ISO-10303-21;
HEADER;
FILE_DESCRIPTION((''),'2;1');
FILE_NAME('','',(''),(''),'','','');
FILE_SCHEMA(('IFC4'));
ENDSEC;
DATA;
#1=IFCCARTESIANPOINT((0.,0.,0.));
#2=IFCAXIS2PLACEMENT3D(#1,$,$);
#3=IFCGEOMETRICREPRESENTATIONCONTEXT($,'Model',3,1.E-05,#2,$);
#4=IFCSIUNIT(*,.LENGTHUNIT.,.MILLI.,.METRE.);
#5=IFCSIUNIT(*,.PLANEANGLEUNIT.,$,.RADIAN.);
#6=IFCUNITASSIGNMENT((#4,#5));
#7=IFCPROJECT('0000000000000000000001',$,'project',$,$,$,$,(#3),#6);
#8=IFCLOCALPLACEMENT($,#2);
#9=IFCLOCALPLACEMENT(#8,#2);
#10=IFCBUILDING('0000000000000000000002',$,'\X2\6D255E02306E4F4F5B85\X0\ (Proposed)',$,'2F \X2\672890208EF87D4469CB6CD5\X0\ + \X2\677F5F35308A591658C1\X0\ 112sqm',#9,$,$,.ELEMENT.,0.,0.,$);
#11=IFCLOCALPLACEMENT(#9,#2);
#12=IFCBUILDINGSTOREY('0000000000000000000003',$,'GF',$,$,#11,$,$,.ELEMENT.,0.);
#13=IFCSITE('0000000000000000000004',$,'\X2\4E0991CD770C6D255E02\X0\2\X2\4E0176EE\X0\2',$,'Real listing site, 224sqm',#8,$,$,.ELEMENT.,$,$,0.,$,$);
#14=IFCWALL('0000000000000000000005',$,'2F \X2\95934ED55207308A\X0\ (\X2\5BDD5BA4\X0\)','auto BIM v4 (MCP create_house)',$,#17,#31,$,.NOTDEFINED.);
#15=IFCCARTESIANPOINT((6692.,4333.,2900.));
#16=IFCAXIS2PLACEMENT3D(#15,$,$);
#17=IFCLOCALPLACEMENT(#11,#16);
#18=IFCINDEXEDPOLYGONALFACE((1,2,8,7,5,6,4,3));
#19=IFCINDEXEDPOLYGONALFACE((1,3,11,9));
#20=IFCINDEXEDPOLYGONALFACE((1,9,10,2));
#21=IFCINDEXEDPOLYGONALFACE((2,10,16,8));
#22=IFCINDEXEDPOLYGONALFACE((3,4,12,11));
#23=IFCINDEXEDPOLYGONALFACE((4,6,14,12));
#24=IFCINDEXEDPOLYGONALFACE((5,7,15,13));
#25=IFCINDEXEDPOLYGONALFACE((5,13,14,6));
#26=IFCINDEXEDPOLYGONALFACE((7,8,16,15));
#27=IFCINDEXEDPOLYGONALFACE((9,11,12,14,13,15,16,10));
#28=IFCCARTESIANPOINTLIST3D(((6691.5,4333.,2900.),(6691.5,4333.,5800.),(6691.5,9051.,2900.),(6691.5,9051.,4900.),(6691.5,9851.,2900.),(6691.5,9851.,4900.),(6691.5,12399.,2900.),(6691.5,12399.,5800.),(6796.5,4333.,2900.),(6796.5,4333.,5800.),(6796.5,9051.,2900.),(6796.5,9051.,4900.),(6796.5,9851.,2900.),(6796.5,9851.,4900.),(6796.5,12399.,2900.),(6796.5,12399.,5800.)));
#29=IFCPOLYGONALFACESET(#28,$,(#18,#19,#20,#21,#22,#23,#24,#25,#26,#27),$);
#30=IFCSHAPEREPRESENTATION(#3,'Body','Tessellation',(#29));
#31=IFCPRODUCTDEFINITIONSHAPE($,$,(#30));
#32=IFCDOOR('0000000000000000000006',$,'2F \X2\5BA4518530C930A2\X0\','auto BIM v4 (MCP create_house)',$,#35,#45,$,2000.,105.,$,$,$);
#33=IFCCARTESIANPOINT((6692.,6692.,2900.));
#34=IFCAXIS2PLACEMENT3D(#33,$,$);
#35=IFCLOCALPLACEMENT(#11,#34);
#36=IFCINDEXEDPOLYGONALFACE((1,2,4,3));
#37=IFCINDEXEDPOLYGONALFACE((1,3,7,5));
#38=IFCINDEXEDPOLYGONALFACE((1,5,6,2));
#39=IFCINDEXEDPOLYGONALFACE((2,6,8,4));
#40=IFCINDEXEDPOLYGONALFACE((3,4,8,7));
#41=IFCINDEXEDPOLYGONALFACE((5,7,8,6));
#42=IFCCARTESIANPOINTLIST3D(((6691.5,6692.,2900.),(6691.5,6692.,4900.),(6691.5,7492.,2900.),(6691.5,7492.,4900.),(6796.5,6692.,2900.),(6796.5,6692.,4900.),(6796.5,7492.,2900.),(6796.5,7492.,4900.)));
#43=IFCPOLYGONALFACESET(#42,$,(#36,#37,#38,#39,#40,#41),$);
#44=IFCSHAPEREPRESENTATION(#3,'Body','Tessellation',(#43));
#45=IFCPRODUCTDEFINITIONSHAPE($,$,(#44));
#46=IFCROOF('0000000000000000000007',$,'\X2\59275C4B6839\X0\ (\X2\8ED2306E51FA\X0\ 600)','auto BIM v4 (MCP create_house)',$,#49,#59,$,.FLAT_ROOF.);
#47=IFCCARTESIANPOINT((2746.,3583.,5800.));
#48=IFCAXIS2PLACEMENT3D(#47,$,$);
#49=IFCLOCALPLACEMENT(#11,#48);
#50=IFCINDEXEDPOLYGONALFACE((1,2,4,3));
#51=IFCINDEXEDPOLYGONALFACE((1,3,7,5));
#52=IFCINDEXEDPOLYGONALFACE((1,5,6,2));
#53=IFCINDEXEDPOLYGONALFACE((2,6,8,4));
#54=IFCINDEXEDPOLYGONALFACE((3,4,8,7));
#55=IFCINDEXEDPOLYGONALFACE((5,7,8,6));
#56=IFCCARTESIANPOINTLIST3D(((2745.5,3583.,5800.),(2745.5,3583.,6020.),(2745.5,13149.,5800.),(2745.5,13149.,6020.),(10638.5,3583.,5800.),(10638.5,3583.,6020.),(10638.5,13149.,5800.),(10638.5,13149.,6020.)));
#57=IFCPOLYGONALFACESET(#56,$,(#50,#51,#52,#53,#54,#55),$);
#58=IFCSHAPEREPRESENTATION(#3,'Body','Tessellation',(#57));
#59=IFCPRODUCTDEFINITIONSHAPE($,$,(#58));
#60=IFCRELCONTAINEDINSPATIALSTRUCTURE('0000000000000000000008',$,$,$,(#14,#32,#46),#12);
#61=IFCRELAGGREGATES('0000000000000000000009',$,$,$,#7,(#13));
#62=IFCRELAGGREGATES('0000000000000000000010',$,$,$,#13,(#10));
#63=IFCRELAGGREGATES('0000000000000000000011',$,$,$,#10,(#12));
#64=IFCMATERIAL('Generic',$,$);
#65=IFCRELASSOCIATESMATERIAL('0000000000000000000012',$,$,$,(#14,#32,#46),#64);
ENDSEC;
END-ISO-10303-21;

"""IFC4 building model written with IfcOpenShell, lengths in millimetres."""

from ifc_helpers import new_model, si_unit, frame, frame_2d, origin, place, context, project, spatial, rectangle, extrude, material, element, fill, save


model = new_model("IFC4")

# Units and contexts
model_context = context("Model", 3, precision=1e-05, world=origin())
ifc_project = project(units=[si_unit("LENGTHUNIT", "METRE", prefix="MILLI"), si_unit("PLANEANGLEUNIT", "RADIAN")], contexts=[model_context])

# Site, building, storey
site_placement = place(None, origin())
site = spatial("IfcSite", under=ifc_project, at=site_placement, Name="三重県津市2丁目2", ObjectType="Real listing site, 224sqm", CompositionType="ELEMENT", RefElevation=0.0)
building_placement = place(site_placement, origin())
building = spatial("IfcBuilding", under=site, at=building_placement, Name="津市の住宅 (Proposed)", ObjectType="2F 木造軸組構法 + 板張り外壁 112sqm", CompositionType="ELEMENT", ElevationOfRefHeight=0.0, ElevationOfTerrain=0.0)
storey_placement = place(building_placement, origin())
storey = spatial("IfcBuildingStorey", under=building, at=storey_placement, Name="GF", CompositionType="ELEMENT", Elevation=0.0)

# Shared definitions
ifc_material = material(Name="Generic")

# Wall, opening, door
wall_1_placement = place(storey_placement, frame((6692.0, 4333.0, 2900.0)))
wall_1 = element("IfcWall", 1, at=wall_1_placement, inside=storey, material=ifc_material, Name="2F 間仕切り (寝室)", Description="auto BIM v4 (MCP create_house)", PredefinedType="NOTDEFINED", context=model_context, shape_type="SweptSolid", body=[
    extrude(rectangle(XDim=105.0, YDim=8066.0, at=frame_2d((52.0, 4033.0))), frame((6692.0, 4333.0, 2900.0)), (0.0, 0.0, 1.0), 2900.0),
])
opening_1_placement = place(storey_placement, frame((6692.0, 6692.0, 2900.0)))
opening_1 = element("IfcOpeningElement", 2, at=opening_1_placement, cuts=wall_1, PredefinedType="NOTDEFINED", context=model_context, shape_type="SweptSolid", body=[
    extrude(rectangle(XDim=105.0, YDim=800.0, at=frame_2d((52.0, 400.0))), frame((6692.0, 6692.0, 2900.0)), (0.0, 0.0, 1.0), 2000.0),
])
door_1_placement = place(storey_placement, frame((6692.0, 6692.0, 2900.0)))
door_1 = element("IfcDoor", 3, at=door_1_placement, inside=storey, material=ifc_material, Name="2F 室内ドア", Description="auto BIM v4 (MCP create_house)", OverallHeight=2000.0, OverallWidth=105.0, context=model_context, shape_type="SweptSolid", body=[
    extrude(rectangle(XDim=105.0, YDim=800.0, at=frame_2d((52.0, 400.0))), frame((6692.0, 6692.0, 2900.0)), (0.0, 0.0, 1.0), 2000.0),
])
fill(opening_1, door_1)

# Roof
roof_placement = place(storey_placement, frame((2746.0, 3583.0, 5800.0)))
element("IfcRoof", 4, at=roof_placement, inside=storey, material=ifc_material, Name="大屋根 (軒の出 600)", Description="auto BIM v4 (MCP create_house)", PredefinedType="FLAT_ROOF", context=model_context, shape_type="SweptSolid", body=[
    extrude(rectangle(XDim=7893.0, YDim=9566.0, at=frame_2d((3946.0, 4783.0))), frame((2746.0, 3583.0, 5800.0)), (0.0, 0.0, 1.0), 220.0),
])

save(model, "model.ifc")
